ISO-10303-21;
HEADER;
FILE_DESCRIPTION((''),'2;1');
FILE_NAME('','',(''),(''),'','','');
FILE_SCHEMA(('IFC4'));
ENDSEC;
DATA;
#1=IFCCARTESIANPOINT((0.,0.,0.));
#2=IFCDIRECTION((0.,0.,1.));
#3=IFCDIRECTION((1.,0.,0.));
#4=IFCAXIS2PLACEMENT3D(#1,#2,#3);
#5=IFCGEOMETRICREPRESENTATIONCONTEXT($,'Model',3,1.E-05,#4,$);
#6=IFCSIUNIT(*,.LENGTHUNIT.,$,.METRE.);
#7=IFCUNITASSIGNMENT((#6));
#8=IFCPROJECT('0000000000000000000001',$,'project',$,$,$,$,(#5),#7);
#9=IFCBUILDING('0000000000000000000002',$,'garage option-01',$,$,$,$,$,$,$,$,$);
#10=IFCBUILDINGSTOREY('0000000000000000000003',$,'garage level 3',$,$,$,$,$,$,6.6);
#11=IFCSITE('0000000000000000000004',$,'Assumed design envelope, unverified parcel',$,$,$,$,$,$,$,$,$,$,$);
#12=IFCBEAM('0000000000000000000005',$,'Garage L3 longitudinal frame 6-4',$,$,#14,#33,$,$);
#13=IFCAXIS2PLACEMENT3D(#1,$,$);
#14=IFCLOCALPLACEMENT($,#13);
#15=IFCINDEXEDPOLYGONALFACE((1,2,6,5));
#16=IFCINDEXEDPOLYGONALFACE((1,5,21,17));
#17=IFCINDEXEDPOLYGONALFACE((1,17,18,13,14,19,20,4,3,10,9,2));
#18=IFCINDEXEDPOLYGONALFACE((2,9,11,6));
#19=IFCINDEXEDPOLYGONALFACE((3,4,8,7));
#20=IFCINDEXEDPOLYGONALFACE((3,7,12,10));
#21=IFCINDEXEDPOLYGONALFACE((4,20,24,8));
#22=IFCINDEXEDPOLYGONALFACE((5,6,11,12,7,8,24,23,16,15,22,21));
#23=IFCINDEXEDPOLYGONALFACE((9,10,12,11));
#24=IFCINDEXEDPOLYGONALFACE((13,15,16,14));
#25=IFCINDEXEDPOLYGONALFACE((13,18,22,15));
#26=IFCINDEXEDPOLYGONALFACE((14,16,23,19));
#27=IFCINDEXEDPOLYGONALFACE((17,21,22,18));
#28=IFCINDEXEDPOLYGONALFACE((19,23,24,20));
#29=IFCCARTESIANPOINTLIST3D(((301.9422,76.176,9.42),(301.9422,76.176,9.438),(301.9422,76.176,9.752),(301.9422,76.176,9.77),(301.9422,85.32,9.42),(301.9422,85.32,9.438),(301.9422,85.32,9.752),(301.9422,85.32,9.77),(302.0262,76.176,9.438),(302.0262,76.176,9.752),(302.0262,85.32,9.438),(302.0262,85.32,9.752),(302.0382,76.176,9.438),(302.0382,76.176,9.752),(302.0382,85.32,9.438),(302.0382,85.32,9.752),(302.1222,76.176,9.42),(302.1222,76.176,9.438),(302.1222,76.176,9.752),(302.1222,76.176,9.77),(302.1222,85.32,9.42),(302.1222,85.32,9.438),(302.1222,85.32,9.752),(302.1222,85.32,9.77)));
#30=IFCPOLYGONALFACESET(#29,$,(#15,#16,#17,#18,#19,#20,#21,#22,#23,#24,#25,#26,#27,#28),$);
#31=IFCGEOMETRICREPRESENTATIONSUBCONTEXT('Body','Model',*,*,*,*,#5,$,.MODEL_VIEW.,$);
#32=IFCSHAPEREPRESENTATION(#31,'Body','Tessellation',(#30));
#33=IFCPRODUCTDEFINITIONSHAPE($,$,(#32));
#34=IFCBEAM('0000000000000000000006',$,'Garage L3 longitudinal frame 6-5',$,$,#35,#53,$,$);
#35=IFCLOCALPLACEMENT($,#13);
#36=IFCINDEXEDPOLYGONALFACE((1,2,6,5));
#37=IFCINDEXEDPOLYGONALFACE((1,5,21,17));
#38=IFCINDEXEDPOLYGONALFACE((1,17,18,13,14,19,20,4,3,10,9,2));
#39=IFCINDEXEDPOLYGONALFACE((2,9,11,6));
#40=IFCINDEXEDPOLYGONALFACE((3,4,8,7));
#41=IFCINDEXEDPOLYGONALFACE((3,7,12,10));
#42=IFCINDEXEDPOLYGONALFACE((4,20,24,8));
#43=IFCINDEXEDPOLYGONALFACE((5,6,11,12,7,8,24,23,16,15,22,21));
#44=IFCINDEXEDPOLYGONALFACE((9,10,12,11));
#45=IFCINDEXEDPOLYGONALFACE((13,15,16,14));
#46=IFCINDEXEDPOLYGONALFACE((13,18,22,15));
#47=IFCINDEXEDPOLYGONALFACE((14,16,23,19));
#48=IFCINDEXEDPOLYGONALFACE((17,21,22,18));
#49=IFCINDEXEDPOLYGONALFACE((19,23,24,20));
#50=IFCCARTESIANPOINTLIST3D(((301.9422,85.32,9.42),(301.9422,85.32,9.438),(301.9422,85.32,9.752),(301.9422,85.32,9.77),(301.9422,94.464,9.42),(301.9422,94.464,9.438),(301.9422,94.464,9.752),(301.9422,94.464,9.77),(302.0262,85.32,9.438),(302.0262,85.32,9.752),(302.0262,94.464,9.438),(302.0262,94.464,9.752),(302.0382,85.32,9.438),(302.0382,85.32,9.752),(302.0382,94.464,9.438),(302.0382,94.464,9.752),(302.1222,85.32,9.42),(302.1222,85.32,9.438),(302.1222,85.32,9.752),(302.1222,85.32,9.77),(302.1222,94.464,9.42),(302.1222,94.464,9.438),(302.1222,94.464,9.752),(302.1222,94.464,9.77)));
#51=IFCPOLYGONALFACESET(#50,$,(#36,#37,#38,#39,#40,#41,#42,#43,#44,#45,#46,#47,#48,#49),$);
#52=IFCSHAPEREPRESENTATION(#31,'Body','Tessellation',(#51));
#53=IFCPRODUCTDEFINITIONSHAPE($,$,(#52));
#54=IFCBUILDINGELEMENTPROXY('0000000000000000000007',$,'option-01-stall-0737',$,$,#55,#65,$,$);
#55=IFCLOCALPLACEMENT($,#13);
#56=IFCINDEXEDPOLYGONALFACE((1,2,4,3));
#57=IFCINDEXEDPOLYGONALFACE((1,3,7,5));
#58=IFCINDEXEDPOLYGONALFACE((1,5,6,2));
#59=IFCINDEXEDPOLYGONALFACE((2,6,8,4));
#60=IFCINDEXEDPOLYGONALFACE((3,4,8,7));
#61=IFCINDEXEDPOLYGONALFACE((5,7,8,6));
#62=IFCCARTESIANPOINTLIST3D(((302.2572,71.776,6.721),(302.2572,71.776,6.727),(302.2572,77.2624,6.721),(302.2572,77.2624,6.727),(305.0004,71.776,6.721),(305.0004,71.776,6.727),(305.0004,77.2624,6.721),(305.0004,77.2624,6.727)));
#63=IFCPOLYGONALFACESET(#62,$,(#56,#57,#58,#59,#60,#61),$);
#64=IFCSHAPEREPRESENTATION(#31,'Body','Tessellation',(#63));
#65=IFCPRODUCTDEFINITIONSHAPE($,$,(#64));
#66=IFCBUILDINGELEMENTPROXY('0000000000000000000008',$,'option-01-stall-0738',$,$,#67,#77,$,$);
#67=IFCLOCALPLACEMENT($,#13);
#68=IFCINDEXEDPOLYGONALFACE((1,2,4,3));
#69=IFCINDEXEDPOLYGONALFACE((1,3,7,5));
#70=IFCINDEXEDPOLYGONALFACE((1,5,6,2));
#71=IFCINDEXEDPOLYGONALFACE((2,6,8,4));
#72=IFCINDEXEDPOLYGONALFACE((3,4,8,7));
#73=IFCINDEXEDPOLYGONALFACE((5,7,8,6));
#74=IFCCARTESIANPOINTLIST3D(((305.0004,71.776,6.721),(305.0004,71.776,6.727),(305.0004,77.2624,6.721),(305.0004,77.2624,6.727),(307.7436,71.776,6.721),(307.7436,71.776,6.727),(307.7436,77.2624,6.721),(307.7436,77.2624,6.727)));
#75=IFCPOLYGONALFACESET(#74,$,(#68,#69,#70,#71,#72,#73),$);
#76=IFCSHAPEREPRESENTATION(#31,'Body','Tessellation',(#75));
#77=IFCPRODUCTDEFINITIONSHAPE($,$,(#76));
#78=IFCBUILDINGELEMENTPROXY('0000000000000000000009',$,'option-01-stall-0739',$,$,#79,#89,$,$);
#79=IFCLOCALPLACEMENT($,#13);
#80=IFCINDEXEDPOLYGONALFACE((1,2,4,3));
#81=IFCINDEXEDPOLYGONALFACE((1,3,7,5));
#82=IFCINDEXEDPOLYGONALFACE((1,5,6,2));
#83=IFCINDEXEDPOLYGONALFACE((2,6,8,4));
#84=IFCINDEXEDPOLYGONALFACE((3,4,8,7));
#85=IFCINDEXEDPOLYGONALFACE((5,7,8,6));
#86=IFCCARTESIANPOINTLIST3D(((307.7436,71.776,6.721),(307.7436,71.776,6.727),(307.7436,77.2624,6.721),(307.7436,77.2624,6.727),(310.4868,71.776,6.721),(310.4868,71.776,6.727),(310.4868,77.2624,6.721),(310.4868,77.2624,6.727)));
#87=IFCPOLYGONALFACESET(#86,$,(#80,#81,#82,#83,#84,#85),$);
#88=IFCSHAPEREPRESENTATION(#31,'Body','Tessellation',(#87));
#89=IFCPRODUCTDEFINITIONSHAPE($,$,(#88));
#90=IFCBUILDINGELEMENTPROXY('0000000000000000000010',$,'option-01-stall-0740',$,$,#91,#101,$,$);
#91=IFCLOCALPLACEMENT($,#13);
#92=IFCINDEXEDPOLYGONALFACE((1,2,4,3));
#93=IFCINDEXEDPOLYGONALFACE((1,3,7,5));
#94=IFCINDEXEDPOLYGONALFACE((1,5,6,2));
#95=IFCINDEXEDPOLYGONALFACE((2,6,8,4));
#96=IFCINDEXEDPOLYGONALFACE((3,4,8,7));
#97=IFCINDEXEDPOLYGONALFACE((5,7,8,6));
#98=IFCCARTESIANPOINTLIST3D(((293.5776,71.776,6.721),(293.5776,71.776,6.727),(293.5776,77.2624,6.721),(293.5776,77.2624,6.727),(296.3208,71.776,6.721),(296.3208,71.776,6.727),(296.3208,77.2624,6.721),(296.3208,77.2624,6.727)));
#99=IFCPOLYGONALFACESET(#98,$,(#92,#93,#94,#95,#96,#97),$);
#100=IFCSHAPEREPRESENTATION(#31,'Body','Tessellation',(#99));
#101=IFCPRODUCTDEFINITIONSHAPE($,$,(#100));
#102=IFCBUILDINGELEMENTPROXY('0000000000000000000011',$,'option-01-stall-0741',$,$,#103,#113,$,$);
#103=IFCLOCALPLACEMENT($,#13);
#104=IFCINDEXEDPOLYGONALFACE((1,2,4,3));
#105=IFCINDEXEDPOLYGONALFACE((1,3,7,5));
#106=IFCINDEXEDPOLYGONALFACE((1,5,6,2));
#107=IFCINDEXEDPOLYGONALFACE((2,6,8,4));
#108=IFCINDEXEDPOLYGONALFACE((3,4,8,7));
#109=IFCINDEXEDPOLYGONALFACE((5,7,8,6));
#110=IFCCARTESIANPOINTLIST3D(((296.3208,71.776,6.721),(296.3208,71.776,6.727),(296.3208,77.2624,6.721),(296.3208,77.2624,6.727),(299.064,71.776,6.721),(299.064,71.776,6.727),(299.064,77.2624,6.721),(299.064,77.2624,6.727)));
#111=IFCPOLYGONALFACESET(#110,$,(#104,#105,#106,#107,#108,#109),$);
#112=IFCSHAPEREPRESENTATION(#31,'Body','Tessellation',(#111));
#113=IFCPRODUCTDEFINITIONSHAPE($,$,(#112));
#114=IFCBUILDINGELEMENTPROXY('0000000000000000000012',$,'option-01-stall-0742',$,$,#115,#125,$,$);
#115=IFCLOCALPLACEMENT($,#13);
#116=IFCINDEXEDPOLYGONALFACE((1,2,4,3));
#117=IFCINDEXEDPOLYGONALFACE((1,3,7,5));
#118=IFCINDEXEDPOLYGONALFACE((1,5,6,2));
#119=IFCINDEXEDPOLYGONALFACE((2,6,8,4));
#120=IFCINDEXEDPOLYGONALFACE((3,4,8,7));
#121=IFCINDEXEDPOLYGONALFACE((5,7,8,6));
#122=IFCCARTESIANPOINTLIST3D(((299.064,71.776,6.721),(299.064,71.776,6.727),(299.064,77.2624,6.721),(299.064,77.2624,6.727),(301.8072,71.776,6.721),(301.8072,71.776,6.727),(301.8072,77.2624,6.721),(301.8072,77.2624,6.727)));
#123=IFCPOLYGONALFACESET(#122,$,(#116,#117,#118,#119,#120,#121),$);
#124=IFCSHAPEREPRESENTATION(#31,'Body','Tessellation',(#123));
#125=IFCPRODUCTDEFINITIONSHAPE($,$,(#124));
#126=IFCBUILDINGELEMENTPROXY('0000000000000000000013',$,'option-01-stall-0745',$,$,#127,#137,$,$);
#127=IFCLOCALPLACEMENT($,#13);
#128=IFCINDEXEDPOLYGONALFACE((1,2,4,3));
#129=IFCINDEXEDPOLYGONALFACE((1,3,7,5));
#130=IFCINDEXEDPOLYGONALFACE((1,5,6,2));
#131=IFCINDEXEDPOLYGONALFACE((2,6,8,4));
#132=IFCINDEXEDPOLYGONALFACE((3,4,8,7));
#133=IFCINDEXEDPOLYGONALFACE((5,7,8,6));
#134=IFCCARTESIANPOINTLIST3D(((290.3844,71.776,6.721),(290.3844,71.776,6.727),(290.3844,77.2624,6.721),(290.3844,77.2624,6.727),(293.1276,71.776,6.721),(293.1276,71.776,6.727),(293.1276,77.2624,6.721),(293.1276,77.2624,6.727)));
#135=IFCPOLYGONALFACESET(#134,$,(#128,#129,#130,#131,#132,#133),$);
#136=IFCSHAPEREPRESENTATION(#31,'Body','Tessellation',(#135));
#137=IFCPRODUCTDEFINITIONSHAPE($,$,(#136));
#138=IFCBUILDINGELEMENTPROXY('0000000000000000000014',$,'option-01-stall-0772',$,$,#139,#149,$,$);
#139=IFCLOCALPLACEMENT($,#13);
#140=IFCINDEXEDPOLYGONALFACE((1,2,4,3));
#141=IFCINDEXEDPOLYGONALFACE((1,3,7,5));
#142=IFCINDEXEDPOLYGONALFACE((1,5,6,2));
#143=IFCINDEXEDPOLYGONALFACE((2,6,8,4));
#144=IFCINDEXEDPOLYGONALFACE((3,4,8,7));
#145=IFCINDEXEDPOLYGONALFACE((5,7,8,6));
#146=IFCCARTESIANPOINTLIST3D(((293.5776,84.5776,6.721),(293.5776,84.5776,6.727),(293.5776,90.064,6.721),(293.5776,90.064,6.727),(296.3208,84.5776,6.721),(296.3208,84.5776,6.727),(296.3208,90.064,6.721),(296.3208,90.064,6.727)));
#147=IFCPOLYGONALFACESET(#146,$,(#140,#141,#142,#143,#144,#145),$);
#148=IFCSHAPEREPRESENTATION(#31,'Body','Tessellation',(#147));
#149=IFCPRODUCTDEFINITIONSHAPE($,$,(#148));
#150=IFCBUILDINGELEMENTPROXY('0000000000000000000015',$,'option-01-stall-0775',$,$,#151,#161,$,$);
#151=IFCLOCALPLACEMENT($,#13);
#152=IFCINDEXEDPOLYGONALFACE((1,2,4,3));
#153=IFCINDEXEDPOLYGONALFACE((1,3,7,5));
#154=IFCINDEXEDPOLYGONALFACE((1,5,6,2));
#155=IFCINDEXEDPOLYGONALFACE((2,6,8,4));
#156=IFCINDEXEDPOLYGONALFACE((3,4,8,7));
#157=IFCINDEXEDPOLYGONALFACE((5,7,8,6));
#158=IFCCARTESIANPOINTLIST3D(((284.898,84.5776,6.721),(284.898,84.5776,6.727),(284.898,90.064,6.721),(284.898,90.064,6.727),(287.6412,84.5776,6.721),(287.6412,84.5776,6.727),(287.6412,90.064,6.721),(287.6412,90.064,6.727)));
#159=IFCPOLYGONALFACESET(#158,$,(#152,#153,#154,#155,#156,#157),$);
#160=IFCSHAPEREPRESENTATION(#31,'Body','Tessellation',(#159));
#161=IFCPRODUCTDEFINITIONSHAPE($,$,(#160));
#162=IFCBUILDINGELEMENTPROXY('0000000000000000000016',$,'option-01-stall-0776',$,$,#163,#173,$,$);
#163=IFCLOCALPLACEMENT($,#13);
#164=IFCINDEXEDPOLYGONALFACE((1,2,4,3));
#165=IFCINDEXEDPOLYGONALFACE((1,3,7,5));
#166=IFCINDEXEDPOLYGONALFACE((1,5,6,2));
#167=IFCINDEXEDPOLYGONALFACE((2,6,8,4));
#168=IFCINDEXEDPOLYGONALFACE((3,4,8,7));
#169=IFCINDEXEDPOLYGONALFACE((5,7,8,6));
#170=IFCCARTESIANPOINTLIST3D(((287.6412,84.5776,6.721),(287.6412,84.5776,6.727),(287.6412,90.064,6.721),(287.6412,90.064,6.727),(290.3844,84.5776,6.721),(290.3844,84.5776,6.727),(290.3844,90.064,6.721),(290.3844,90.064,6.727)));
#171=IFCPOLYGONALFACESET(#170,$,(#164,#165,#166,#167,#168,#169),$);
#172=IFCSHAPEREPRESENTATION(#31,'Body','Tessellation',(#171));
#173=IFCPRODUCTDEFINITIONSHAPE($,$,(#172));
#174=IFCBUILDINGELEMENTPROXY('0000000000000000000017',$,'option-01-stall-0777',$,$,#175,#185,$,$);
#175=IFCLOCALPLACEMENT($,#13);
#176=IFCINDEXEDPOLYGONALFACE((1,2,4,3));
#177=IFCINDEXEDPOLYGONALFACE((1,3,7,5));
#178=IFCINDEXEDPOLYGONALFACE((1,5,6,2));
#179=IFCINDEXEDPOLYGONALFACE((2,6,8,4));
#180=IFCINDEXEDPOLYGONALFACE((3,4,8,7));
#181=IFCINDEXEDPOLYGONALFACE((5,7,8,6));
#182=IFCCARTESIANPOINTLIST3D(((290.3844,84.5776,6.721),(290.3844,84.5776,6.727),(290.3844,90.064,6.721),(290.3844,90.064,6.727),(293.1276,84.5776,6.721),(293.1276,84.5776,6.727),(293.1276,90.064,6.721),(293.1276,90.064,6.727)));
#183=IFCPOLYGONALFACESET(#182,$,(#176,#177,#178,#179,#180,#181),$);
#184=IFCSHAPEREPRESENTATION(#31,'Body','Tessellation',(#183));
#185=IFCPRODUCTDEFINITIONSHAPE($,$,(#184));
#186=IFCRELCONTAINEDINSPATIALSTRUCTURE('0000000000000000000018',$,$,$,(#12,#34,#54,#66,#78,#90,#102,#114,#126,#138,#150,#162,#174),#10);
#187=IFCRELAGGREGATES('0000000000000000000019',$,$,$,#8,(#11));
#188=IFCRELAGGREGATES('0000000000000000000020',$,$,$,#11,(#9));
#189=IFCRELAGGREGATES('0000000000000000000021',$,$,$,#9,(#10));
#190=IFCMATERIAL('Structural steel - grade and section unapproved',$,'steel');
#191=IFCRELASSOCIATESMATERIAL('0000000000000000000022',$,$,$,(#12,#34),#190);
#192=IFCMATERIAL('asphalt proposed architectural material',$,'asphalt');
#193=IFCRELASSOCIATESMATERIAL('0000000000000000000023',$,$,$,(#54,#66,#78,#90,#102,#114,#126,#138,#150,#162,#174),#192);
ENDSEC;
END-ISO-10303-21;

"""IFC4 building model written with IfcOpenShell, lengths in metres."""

from ifc_helpers import new_model, si_unit, frame, origin_with_axes, place, context, subcontext, project, spatial, rectangle, i_section, extrude, material, element, save


model = new_model("IFC4")

# Units and contexts
model_context = context("Model", 3, precision=1e-05, world=origin_with_axes())
body_context = subcontext(model_context, "Body", "Model", "MODEL_VIEW")
ifc_project = project(units=[si_unit("LENGTHUNIT", "METRE")], contexts=[model_context])

# Site, building, storey
site = spatial("IfcSite", under=ifc_project, Name="Assumed design envelope, unverified parcel")
building = spatial("IfcBuilding", under=site, Name="garage option-01")
storey = spatial("IfcBuildingStorey", under=building, Name="garage level 3", Elevation=6.6)

# Beams
ifc_material_1 = material(Name="Structural steel - grade and section unapproved", Category="steel")
for number, where, z_axis, x_axis, name in (
    (1, (302.0322, 76.176, 9.595), (0.0, 1.0, 0.0), (-1.0, 0.0, 0.0), "Garage L3 longitudinal frame 6-4"),
    (2, (302.0322, 85.32, 9.595), (0.0, 1.0, 0.0), (-1.0, 0.0, 0.0), "Garage L3 longitudinal frame 6-5"),
):
    element("IfcBeam", number, at=place(None, frame(where, z_axis=z_axis, x_axis=x_axis)), inside=storey, material=ifc_material_1, Name=name, context=body_context, shape_type="SweptSolid", body=[
        extrude(i_section(OverallWidth=0.18, OverallDepth=0.35, WebThickness=0.012, FlangeThickness=0.018, FilletRadius=0.0), origin_with_axes(), (0.0, 0.0, 1.0), 9.144),
    ])

# Building element proxies
ifc_material_2 = material(Name="asphalt proposed architectural material", Category="asphalt")
for number, where, z_axis, x_axis, name in (
    (3, (303.6288, 74.5192, 6.721), (0.0, 0.0, 1.0), (1.0, 0.0, 0.0), "option-01-stall-0737"),
    (4, (306.372, 74.5192, 6.721), (0.0, 0.0, 1.0), (1.0, 0.0, 0.0), "option-01-stall-0738"),
    (5, (309.1152, 74.5192, 6.721), (0.0, 0.0, 1.0), (1.0, 0.0, 0.0), "option-01-stall-0739"),
    (6, (294.9492, 74.5192, 6.721), (0.0, 0.0, 1.0), (1.0, 0.0, 0.0), "option-01-stall-0740"),
    (7, (297.6924, 74.5192, 6.721), (0.0, 0.0, 1.0), (1.0, 0.0, 0.0), "option-01-stall-0741"),
    (8, (300.4356, 74.5192, 6.721), (0.0, 0.0, 1.0), (1.0, 0.0, 0.0), "option-01-stall-0742"),
    (9, (291.756, 74.5192, 6.721), (0.0, 0.0, 1.0), (1.0, 0.0, 0.0), "option-01-stall-0745"),
    (10, (294.9492, 87.3208, 6.721), (0.0, 0.0, 1.0), (1.0, 0.0, 0.0), "option-01-stall-0772"),
    (11, (286.2696, 87.3208, 6.721), (0.0, 0.0, 1.0), (1.0, 0.0, 0.0), "option-01-stall-0775"),
    (12, (289.0128, 87.3208, 6.721), (0.0, 0.0, 1.0), (1.0, 0.0, 0.0), "option-01-stall-0776"),
    (13, (291.756, 87.3208, 6.721), (0.0, 0.0, 1.0), (1.0, 0.0, 0.0), "option-01-stall-0777"),
):
    element("IfcBuildingElementProxy", number, at=place(None, frame(where, z_axis=z_axis, x_axis=x_axis)), inside=storey, material=ifc_material_2, Name=name, context=body_context, shape_type="SweptSolid", body=[
        extrude(rectangle(XDim=2.7432, YDim=5.4864), origin_with_axes(), (0.0, 0.0, 1.0), 0.006),
    ])

save(model, "model.ifc")
